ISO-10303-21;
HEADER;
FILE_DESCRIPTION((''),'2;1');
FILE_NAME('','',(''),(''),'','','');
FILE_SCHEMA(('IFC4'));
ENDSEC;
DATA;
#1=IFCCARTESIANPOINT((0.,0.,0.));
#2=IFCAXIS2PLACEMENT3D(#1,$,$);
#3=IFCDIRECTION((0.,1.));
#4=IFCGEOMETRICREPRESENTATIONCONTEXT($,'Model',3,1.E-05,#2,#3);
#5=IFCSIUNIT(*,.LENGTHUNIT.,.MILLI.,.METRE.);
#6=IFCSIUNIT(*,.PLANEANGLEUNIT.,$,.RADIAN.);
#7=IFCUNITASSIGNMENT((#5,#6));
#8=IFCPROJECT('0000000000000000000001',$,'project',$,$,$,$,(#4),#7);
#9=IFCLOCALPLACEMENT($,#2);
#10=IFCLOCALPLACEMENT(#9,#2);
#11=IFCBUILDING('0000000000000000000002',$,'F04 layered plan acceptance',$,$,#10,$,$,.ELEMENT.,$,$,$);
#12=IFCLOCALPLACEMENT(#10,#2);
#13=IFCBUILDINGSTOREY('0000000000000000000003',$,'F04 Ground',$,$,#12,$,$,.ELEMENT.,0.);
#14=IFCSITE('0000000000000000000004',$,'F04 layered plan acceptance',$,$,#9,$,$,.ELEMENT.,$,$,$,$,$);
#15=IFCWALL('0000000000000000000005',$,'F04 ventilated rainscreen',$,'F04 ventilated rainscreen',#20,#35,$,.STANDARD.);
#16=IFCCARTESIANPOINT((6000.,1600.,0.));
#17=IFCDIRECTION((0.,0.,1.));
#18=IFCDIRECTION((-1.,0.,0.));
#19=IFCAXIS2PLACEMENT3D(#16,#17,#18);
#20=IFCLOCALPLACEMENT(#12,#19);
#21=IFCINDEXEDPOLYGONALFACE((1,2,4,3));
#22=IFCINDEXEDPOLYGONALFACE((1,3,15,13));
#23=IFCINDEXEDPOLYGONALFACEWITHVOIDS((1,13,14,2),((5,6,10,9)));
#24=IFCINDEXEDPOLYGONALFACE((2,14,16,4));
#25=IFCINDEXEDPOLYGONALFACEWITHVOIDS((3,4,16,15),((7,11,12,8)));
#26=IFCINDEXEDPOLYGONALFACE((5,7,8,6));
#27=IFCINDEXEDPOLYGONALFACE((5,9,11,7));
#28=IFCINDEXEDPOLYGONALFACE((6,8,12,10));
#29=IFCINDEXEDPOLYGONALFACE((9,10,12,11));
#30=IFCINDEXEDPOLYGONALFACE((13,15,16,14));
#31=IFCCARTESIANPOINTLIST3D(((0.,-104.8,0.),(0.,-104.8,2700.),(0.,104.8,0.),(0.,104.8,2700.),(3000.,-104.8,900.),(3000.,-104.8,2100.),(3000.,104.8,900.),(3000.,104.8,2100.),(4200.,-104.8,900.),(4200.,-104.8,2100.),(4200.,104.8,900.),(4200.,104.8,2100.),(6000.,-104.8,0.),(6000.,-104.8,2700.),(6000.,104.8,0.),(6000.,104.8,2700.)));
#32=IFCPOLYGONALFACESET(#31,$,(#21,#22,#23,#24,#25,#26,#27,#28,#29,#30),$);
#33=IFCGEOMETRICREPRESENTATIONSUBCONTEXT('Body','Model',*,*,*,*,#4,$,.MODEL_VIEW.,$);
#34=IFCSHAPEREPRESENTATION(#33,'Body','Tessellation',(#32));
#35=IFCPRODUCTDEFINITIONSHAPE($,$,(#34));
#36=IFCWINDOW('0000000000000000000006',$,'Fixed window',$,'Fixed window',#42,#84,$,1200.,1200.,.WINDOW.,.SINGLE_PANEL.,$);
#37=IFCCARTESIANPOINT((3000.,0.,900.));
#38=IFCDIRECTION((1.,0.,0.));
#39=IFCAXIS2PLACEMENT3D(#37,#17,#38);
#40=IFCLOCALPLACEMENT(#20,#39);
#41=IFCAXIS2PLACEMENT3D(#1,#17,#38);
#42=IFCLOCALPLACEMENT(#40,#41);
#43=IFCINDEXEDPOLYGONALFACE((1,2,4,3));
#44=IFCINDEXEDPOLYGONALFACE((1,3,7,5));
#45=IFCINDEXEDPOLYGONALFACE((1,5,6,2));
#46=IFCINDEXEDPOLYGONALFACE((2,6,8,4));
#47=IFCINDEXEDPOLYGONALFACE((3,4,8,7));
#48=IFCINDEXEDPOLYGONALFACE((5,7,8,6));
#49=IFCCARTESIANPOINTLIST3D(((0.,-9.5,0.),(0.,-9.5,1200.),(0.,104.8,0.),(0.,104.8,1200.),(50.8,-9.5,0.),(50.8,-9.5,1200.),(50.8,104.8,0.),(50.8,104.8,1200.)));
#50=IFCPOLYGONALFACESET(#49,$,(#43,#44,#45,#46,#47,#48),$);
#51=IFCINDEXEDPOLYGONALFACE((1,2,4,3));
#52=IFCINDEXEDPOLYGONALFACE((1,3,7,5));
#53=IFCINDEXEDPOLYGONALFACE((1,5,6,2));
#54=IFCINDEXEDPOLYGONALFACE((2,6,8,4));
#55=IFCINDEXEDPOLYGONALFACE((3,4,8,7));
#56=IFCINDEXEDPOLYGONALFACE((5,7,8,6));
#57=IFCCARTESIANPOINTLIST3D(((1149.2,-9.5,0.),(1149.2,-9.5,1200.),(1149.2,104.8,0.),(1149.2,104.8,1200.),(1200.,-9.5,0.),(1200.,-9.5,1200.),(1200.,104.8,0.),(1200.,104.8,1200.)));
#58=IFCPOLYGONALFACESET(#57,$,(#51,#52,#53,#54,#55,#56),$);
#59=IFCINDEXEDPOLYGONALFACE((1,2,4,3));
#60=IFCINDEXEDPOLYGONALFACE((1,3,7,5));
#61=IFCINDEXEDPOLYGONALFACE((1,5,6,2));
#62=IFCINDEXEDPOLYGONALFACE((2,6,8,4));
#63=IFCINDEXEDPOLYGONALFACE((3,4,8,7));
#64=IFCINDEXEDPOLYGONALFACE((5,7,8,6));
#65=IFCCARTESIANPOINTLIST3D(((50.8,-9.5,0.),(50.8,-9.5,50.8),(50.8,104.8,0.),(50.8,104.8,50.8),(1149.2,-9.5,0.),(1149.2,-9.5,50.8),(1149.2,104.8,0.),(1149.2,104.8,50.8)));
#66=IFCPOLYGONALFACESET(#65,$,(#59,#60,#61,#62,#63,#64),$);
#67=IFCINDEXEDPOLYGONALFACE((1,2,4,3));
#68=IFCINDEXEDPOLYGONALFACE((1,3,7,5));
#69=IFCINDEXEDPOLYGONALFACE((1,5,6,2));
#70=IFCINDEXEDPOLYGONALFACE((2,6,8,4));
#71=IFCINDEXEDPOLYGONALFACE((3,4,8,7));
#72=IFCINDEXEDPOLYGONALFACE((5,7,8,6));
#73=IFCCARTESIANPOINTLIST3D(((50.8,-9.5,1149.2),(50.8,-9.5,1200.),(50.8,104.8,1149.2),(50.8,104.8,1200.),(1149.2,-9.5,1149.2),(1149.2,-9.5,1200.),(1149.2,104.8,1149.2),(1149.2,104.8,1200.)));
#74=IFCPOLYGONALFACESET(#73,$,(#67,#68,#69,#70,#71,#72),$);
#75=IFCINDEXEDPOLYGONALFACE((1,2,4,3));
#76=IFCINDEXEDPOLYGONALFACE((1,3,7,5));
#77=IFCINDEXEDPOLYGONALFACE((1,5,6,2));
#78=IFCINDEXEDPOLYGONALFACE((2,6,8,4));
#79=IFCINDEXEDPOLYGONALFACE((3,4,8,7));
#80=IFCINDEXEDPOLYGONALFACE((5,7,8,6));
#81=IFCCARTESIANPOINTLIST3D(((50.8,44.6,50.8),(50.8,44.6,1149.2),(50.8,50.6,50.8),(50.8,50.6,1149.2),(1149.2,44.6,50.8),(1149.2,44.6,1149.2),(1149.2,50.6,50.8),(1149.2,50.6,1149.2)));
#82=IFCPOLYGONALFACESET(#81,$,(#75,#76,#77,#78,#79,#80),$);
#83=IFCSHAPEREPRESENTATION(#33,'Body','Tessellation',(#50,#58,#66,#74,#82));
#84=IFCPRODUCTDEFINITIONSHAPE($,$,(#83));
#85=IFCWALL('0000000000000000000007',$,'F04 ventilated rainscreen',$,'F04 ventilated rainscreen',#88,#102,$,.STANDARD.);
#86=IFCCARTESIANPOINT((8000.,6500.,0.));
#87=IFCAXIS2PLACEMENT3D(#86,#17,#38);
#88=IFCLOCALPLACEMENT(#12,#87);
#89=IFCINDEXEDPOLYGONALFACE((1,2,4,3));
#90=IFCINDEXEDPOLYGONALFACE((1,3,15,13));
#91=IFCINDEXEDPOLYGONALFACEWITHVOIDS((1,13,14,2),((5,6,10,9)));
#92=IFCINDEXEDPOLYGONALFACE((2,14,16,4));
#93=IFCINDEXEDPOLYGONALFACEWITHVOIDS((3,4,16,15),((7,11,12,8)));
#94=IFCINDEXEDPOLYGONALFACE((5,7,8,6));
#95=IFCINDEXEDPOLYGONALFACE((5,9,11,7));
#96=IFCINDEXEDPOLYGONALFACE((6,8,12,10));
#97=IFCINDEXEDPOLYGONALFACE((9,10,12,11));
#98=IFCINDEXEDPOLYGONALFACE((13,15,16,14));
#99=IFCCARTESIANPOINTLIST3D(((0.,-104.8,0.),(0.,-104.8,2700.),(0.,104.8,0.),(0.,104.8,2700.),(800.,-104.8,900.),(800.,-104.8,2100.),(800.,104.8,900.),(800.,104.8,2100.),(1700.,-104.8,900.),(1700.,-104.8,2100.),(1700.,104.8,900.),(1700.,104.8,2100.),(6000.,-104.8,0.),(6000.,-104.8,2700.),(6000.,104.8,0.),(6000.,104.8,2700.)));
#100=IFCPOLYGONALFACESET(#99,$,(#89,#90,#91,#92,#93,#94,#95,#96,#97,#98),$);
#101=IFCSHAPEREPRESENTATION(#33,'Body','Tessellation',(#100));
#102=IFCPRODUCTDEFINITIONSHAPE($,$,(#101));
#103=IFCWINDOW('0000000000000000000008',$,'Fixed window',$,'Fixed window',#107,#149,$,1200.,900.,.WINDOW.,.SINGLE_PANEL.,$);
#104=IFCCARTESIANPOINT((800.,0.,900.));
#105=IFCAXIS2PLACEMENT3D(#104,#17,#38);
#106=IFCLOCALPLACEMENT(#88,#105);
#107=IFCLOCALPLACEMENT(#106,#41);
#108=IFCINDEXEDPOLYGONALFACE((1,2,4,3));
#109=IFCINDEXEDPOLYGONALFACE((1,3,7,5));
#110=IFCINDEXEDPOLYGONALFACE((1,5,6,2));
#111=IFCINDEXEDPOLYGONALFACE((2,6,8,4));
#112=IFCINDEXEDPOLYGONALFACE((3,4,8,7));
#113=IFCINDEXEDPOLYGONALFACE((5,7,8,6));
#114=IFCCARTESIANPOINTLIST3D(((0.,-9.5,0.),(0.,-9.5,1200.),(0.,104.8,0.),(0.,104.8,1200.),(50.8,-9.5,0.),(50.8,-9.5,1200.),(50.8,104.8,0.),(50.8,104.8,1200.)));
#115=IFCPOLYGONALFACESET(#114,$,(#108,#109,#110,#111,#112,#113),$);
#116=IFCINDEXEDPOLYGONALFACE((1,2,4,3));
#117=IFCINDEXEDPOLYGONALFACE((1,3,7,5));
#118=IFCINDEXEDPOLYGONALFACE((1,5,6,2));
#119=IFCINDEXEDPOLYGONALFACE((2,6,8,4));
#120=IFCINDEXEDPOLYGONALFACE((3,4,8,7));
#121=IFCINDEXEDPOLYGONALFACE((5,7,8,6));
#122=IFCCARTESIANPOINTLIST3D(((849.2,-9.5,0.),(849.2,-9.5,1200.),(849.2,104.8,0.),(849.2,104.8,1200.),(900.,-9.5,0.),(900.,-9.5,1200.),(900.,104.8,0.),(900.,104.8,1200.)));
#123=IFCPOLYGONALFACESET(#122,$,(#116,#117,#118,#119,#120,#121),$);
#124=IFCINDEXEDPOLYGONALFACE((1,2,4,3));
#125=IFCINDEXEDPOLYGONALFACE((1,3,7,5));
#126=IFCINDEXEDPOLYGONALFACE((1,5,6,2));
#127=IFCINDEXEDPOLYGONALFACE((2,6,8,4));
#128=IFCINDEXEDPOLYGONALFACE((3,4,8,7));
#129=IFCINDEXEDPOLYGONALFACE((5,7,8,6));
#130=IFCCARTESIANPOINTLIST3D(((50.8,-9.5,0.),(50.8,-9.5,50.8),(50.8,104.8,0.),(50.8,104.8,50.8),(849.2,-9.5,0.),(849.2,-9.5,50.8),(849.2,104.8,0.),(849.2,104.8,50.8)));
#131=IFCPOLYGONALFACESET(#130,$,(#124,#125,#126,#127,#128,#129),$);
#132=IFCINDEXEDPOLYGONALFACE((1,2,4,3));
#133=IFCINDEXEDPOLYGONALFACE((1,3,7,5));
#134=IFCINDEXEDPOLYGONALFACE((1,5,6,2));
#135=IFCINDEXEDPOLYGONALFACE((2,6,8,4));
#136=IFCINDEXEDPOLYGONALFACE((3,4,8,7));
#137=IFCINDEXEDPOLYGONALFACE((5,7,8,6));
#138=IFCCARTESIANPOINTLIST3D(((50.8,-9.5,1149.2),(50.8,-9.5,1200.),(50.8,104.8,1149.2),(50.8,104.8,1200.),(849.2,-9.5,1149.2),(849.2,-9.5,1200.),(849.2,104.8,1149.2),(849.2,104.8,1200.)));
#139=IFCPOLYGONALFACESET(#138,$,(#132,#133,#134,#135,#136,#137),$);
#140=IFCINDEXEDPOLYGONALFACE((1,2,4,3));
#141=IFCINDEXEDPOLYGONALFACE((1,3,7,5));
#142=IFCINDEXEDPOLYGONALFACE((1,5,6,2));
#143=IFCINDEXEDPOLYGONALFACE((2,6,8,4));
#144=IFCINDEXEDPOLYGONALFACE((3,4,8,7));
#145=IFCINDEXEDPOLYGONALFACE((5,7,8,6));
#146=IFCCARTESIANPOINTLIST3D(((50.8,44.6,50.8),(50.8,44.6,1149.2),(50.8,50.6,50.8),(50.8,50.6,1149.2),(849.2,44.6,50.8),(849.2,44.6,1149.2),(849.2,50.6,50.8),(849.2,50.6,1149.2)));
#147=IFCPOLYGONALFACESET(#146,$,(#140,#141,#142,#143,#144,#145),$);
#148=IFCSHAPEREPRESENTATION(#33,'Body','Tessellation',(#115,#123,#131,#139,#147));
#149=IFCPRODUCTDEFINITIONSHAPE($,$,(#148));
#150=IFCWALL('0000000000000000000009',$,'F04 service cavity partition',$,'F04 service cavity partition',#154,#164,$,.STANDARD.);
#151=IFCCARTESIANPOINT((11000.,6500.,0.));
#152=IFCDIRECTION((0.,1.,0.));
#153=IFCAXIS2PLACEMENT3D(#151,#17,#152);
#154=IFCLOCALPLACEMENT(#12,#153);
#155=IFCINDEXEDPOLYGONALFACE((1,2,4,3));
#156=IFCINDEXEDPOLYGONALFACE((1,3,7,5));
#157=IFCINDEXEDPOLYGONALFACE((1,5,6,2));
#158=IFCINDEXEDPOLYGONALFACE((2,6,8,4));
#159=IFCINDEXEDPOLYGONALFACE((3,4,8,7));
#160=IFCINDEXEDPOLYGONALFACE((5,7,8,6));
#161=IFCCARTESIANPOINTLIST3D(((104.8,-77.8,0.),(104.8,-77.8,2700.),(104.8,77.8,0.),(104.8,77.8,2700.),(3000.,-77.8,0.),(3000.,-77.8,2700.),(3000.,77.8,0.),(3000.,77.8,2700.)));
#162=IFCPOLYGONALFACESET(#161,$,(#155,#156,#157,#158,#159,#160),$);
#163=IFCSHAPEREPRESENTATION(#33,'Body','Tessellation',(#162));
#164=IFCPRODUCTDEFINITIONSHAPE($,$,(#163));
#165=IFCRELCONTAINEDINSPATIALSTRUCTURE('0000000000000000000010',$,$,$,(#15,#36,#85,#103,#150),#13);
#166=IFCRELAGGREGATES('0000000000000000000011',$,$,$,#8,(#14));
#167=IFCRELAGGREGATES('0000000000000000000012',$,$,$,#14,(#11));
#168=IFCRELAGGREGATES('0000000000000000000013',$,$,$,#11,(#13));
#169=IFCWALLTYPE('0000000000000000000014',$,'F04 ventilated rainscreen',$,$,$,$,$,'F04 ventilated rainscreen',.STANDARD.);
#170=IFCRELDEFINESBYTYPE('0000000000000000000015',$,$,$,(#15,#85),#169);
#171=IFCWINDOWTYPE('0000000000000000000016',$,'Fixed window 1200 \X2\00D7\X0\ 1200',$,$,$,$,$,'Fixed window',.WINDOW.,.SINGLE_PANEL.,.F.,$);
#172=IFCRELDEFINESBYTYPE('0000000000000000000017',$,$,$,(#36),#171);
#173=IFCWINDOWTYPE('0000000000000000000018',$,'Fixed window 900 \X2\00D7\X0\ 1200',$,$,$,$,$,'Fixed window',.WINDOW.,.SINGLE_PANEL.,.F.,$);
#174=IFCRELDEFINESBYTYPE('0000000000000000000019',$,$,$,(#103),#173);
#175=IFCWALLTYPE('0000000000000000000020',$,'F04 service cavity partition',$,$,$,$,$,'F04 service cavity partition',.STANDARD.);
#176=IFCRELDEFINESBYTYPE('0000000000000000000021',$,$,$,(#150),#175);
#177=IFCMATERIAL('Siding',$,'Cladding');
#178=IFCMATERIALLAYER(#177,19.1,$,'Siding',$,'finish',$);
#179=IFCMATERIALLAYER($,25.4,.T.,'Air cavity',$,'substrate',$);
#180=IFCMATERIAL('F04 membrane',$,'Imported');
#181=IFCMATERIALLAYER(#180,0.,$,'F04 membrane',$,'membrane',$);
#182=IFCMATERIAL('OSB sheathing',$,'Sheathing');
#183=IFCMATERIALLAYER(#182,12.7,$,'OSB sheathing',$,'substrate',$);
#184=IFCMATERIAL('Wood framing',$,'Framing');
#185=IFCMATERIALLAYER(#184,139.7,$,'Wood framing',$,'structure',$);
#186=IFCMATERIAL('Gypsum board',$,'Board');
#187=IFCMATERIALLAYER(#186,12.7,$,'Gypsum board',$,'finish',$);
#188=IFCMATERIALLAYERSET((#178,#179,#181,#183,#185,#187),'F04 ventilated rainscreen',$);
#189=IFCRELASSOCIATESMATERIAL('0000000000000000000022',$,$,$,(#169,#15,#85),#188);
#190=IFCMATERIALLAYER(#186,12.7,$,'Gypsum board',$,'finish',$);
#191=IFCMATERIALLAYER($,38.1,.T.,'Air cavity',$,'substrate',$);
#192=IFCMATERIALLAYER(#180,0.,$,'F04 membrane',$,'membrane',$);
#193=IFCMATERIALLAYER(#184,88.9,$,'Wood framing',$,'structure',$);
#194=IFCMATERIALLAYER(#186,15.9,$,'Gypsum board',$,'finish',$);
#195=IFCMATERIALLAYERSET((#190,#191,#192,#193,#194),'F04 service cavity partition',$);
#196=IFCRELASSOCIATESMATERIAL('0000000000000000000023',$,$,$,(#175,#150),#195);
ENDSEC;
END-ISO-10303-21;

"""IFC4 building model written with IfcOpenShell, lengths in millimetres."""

from ifc_helpers import new_model, si_unit, direction, frame, origin, origin_with_axes, place, context, subcontext, project, spatial, polyline, outline, extrude, material, layer, layer_set, layer_usage, type_object, element, fill, save


model = new_model("IFC4")

# Units and contexts
model_context = context("Model", 3, precision=1e-05, world=origin(), true_north=direction((0.0, 1.0)))
body_context = subcontext(model_context, "Body", "Model", "MODEL_VIEW")
ifc_project = project(units=[si_unit("LENGTHUNIT", "METRE", prefix="MILLI"), si_unit("PLANEANGLEUNIT", "RADIAN")], contexts=[model_context])

# Site, building, storey
site_placement = place(None, origin())
site = spatial("IfcSite", under=ifc_project, at=site_placement, Name="F04 layered plan acceptance", CompositionType="ELEMENT")
building_placement = place(site_placement, origin())
building = spatial("IfcBuilding", under=site, at=building_placement, Name="F04 layered plan acceptance", CompositionType="ELEMENT")
storey_placement = place(building_placement, origin())
storey = spatial("IfcBuildingStorey", under=building, at=storey_placement, Name="F04 Ground", CompositionType="ELEMENT", Elevation=0.0)

# Shared definitions
ifc_material_1 = material(Name="Siding", Category="Cladding")
ifc_layer_1 = layer(ifc_material_1, 19.1, Name="Siding", Category="finish")
ifc_layer_2 = layer(None, 25.4, ventilated=True, Name="Air cavity", Category="substrate")
ifc_material_2 = material(Name="F04 membrane", Category="Imported")
ifc_layer_3 = layer(ifc_material_2, 0.0, Name="F04 membrane", Category="membrane")
ifc_material_3 = material(Name="OSB sheathing", Category="Sheathing")
ifc_layer_4 = layer(ifc_material_3, 12.7, Name="OSB sheathing", Category="substrate")
ifc_material_4 = material(Name="Wood framing", Category="Framing")
ifc_layer_5 = layer(ifc_material_4, 139.7, Name="Wood framing", Category="structure")
ifc_material_5 = material(Name="Gypsum board", Category="Board")
ifc_layer_6 = layer(ifc_material_5, 12.7, Name="Gypsum board", Category="finish")
ifc_layer_set_1 = layer_set([ifc_layer_1, ifc_layer_2, ifc_layer_3, ifc_layer_4, ifc_layer_5, ifc_layer_6], Name="F04 ventilated rainscreen")
wall_type_1 = type_object("IfcWallType", Name="F04 ventilated rainscreen", ElementType="F04 ventilated rainscreen", PredefinedType="STANDARD", material=ifc_layer_set_1)

# Wall, opening, window
ifc_layer_usage_1 = layer_usage(ifc_layer_set_1, "AXIS2", "POSITIVE", -104.8)
wall_1_placement = place(storey_placement, frame((6000.0, 1600.0, 0.0), z_axis=(0.0, 0.0, 1.0), x_axis=(-1.0, 0.0, 0.0)))
wall_1 = element("IfcWall", 1, at=wall_1_placement, inside=storey, type_object=wall_type_1, material=ifc_layer_usage_1, Name="F04 ventilated rainscreen", ObjectType="F04 ventilated rainscreen", PredefinedType="STANDARD", context=body_context, shape_type="SweptSolid", body=[
    extrude(outline(polyline([(0.0, -104.8), (6000.0, -104.8), (6000.0, 104.8), (0.0, 104.8), (0.0, -104.8)])), origin(), (0.0, 0.0, 1.0), 2700.0),
])
opening_1_placement = place(wall_1_placement, frame((3000.0, 0.0, 900.0), z_axis=(0.0, 0.0, 1.0), x_axis=(1.0, 0.0, 0.0)))
opening_1 = element("IfcOpeningElement", 2, at=opening_1_placement, cuts=wall_1, PredefinedType="OPENING", context=body_context, shape_type="SweptSolid", body=[
    extrude(outline(polyline([(0.0, -114.8), (1200.0, -114.8), (1200.0, 114.8), (0.0, 114.8), (0.0, -114.8)])), origin(), (0.0, 0.0, 1.0), 1200.0),
])
window_type_1 = type_object("IfcWindowType", Name="Fixed window 1200 × 1200", ElementType="Fixed window", ParameterTakesPrecedence=False, PartitioningType="SINGLE_PANEL", PredefinedType="WINDOW")
window_1_placement = place(opening_1_placement, origin_with_axes())
window_1 = element("IfcWindow", 3, at=window_1_placement, inside=storey, type_object=window_type_1, Name="Fixed window", ObjectType="Fixed window", OverallHeight=1200.0, OverallWidth=1200.0, PartitioningType="SINGLE_PANEL", PredefinedType="WINDOW", context=body_context, shape_type="SweptSolid", body=[
    extrude(outline(polyline([(0.0, -9.5), (50.8, -9.5), (50.8, 104.8), (0.0, 104.8), (0.0, -9.5)])), origin(), (0.0, 0.0, 1.0), 1200.0),
    extrude(outline(polyline([(1149.2, -9.5), (1200.0, -9.5), (1200.0, 104.8), (1149.2, 104.8), (1149.2, -9.5)])), origin(), (0.0, 0.0, 1.0), 1200.0),
    extrude(outline(polyline([(50.8, -9.5), (1149.2, -9.5), (1149.2, 104.8), (50.8, 104.8), (50.8, -9.5)])), origin(), (0.0, 0.0, 1.0), 50.8),
    extrude(outline(polyline([(50.8, -9.5), (1149.2, -9.5), (1149.2, 104.8), (50.8, 104.8), (50.8, -9.5)])), frame((0.0, 0.0, 1149.2)), (0.0, 0.0, 1.0), 50.8),
    extrude(outline(polyline([(50.8, 44.6), (1149.2, 44.6), (1149.2, 50.6), (50.8, 50.6), (50.8, 44.6)])), frame((0.0, 0.0, 50.8)), (0.0, 0.0, 1.0), 1098.4),
])
fill(opening_1, window_1)

# Wall, opening, window
ifc_layer_usage_2 = layer_usage(ifc_layer_set_1, "AXIS2", "NEGATIVE", 104.8)
wall_2_placement = place(storey_placement, frame((8000.0, 6500.0, 0.0), z_axis=(0.0, 0.0, 1.0), x_axis=(1.0, 0.0, 0.0)))
wall_2 = element("IfcWall", 4, at=wall_2_placement, inside=storey, type_object=wall_type_1, material=ifc_layer_usage_2, Name="F04 ventilated rainscreen", ObjectType="F04 ventilated rainscreen", PredefinedType="STANDARD", context=body_context, shape_type="SweptSolid", body=[
    extrude(outline(polyline([(0.0, -104.8), (6000.0, -104.8), (6000.0, 104.8), (0.0, 104.8), (0.0, -104.8)])), origin(), (0.0, 0.0, 1.0), 2700.0),
])
opening_2_placement = place(wall_2_placement, frame((800.0, 0.0, 900.0), z_axis=(0.0, 0.0, 1.0), x_axis=(1.0, 0.0, 0.0)))
opening_2 = element("IfcOpeningElement", 5, at=opening_2_placement, cuts=wall_2, PredefinedType="OPENING", context=body_context, shape_type="SweptSolid", body=[
    extrude(outline(polyline([(0.0, -114.8), (900.0, -114.8), (900.0, 114.8), (0.0, 114.8), (0.0, -114.8)])), origin(), (0.0, 0.0, 1.0), 1200.0),
])
window_type_2 = type_object("IfcWindowType", Name="Fixed window 900 × 1200", ElementType="Fixed window", ParameterTakesPrecedence=False, PartitioningType="SINGLE_PANEL", PredefinedType="WINDOW")
window_2_placement = place(opening_2_placement, origin_with_axes())
window_2 = element("IfcWindow", 6, at=window_2_placement, inside=storey, type_object=window_type_2, Name="Fixed window", ObjectType="Fixed window", OverallHeight=1200.0, OverallWidth=900.0, PartitioningType="SINGLE_PANEL", PredefinedType="WINDOW", context=body_context, shape_type="SweptSolid", body=[
    extrude(outline(polyline([(0.0, -9.5), (50.8, -9.5), (50.8, 104.8), (0.0, 104.8), (0.0, -9.5)])), origin(), (0.0, 0.0, 1.0), 1200.0),
    extrude(outline(polyline([(849.2, -9.5), (900.0, -9.5), (900.0, 104.8), (849.2, 104.8), (849.2, -9.5)])), origin(), (0.0, 0.0, 1.0), 1200.0),
    extrude(outline(polyline([(50.8, -9.5), (849.2, -9.5), (849.2, 104.8), (50.8, 104.8), (50.8, -9.5)])), origin(), (0.0, 0.0, 1.0), 50.8),
    extrude(outline(polyline([(50.8, -9.5), (849.2, -9.5), (849.2, 104.8), (50.8, 104.8), (50.8, -9.5)])), frame((0.0, 0.0, 1149.2)), (0.0, 0.0, 1.0), 50.8),
    extrude(outline(polyline([(50.8, 44.6), (849.2, 44.6), (849.2, 50.6), (50.8, 50.6), (50.8, 44.6)])), frame((0.0, 0.0, 50.8)), (0.0, 0.0, 1.0), 1098.4),
])
fill(opening_2, window_2)

# Wall
ifc_layer_7 = layer(ifc_material_5, 12.7, Name="Gypsum board", Category="finish")
ifc_layer_8 = layer(None, 38.1, ventilated=True, Name="Air cavity", Category="substrate")
ifc_layer_9 = layer(ifc_material_2, 0.0, Name="F04 membrane", Category="membrane")
ifc_layer_10 = layer(ifc_material_4, 88.9, Name="Wood framing", Category="structure")
ifc_layer_11 = layer(ifc_material_5, 15.9, Name="Gypsum board", Category="finish")
ifc_layer_set_2 = layer_set([ifc_layer_7, ifc_layer_8, ifc_layer_9, ifc_layer_10, ifc_layer_11], Name="F04 service cavity partition")
ifc_layer_usage_3 = layer_usage(ifc_layer_set_2, "AXIS2", "NEGATIVE", 77.8)
wall_type_2 = type_object("IfcWallType", Name="F04 service cavity partition", ElementType="F04 service cavity partition", PredefinedType="STANDARD", material=ifc_layer_set_2)
wall_3_placement = place(storey_placement, frame((11000.0, 6500.0, 0.0), z_axis=(0.0, 0.0, 1.0), x_axis=(0.0, 1.0, 0.0)))
element("IfcWall", 7, at=wall_3_placement, inside=storey, type_object=wall_type_2, material=ifc_layer_usage_3, Name="F04 service cavity partition", ObjectType="F04 service cavity partition", PredefinedType="STANDARD", context=body_context, shape_type="SweptSolid", body=[
    extrude(outline(polyline([(104.8, -77.8), (3000.0, -77.8), (3000.0, 77.8), (104.8, 77.8), (104.8, -77.8)])), origin(), (0.0, 0.0, 1.0), 2700.0),
])

save(model, "model.ifc")
